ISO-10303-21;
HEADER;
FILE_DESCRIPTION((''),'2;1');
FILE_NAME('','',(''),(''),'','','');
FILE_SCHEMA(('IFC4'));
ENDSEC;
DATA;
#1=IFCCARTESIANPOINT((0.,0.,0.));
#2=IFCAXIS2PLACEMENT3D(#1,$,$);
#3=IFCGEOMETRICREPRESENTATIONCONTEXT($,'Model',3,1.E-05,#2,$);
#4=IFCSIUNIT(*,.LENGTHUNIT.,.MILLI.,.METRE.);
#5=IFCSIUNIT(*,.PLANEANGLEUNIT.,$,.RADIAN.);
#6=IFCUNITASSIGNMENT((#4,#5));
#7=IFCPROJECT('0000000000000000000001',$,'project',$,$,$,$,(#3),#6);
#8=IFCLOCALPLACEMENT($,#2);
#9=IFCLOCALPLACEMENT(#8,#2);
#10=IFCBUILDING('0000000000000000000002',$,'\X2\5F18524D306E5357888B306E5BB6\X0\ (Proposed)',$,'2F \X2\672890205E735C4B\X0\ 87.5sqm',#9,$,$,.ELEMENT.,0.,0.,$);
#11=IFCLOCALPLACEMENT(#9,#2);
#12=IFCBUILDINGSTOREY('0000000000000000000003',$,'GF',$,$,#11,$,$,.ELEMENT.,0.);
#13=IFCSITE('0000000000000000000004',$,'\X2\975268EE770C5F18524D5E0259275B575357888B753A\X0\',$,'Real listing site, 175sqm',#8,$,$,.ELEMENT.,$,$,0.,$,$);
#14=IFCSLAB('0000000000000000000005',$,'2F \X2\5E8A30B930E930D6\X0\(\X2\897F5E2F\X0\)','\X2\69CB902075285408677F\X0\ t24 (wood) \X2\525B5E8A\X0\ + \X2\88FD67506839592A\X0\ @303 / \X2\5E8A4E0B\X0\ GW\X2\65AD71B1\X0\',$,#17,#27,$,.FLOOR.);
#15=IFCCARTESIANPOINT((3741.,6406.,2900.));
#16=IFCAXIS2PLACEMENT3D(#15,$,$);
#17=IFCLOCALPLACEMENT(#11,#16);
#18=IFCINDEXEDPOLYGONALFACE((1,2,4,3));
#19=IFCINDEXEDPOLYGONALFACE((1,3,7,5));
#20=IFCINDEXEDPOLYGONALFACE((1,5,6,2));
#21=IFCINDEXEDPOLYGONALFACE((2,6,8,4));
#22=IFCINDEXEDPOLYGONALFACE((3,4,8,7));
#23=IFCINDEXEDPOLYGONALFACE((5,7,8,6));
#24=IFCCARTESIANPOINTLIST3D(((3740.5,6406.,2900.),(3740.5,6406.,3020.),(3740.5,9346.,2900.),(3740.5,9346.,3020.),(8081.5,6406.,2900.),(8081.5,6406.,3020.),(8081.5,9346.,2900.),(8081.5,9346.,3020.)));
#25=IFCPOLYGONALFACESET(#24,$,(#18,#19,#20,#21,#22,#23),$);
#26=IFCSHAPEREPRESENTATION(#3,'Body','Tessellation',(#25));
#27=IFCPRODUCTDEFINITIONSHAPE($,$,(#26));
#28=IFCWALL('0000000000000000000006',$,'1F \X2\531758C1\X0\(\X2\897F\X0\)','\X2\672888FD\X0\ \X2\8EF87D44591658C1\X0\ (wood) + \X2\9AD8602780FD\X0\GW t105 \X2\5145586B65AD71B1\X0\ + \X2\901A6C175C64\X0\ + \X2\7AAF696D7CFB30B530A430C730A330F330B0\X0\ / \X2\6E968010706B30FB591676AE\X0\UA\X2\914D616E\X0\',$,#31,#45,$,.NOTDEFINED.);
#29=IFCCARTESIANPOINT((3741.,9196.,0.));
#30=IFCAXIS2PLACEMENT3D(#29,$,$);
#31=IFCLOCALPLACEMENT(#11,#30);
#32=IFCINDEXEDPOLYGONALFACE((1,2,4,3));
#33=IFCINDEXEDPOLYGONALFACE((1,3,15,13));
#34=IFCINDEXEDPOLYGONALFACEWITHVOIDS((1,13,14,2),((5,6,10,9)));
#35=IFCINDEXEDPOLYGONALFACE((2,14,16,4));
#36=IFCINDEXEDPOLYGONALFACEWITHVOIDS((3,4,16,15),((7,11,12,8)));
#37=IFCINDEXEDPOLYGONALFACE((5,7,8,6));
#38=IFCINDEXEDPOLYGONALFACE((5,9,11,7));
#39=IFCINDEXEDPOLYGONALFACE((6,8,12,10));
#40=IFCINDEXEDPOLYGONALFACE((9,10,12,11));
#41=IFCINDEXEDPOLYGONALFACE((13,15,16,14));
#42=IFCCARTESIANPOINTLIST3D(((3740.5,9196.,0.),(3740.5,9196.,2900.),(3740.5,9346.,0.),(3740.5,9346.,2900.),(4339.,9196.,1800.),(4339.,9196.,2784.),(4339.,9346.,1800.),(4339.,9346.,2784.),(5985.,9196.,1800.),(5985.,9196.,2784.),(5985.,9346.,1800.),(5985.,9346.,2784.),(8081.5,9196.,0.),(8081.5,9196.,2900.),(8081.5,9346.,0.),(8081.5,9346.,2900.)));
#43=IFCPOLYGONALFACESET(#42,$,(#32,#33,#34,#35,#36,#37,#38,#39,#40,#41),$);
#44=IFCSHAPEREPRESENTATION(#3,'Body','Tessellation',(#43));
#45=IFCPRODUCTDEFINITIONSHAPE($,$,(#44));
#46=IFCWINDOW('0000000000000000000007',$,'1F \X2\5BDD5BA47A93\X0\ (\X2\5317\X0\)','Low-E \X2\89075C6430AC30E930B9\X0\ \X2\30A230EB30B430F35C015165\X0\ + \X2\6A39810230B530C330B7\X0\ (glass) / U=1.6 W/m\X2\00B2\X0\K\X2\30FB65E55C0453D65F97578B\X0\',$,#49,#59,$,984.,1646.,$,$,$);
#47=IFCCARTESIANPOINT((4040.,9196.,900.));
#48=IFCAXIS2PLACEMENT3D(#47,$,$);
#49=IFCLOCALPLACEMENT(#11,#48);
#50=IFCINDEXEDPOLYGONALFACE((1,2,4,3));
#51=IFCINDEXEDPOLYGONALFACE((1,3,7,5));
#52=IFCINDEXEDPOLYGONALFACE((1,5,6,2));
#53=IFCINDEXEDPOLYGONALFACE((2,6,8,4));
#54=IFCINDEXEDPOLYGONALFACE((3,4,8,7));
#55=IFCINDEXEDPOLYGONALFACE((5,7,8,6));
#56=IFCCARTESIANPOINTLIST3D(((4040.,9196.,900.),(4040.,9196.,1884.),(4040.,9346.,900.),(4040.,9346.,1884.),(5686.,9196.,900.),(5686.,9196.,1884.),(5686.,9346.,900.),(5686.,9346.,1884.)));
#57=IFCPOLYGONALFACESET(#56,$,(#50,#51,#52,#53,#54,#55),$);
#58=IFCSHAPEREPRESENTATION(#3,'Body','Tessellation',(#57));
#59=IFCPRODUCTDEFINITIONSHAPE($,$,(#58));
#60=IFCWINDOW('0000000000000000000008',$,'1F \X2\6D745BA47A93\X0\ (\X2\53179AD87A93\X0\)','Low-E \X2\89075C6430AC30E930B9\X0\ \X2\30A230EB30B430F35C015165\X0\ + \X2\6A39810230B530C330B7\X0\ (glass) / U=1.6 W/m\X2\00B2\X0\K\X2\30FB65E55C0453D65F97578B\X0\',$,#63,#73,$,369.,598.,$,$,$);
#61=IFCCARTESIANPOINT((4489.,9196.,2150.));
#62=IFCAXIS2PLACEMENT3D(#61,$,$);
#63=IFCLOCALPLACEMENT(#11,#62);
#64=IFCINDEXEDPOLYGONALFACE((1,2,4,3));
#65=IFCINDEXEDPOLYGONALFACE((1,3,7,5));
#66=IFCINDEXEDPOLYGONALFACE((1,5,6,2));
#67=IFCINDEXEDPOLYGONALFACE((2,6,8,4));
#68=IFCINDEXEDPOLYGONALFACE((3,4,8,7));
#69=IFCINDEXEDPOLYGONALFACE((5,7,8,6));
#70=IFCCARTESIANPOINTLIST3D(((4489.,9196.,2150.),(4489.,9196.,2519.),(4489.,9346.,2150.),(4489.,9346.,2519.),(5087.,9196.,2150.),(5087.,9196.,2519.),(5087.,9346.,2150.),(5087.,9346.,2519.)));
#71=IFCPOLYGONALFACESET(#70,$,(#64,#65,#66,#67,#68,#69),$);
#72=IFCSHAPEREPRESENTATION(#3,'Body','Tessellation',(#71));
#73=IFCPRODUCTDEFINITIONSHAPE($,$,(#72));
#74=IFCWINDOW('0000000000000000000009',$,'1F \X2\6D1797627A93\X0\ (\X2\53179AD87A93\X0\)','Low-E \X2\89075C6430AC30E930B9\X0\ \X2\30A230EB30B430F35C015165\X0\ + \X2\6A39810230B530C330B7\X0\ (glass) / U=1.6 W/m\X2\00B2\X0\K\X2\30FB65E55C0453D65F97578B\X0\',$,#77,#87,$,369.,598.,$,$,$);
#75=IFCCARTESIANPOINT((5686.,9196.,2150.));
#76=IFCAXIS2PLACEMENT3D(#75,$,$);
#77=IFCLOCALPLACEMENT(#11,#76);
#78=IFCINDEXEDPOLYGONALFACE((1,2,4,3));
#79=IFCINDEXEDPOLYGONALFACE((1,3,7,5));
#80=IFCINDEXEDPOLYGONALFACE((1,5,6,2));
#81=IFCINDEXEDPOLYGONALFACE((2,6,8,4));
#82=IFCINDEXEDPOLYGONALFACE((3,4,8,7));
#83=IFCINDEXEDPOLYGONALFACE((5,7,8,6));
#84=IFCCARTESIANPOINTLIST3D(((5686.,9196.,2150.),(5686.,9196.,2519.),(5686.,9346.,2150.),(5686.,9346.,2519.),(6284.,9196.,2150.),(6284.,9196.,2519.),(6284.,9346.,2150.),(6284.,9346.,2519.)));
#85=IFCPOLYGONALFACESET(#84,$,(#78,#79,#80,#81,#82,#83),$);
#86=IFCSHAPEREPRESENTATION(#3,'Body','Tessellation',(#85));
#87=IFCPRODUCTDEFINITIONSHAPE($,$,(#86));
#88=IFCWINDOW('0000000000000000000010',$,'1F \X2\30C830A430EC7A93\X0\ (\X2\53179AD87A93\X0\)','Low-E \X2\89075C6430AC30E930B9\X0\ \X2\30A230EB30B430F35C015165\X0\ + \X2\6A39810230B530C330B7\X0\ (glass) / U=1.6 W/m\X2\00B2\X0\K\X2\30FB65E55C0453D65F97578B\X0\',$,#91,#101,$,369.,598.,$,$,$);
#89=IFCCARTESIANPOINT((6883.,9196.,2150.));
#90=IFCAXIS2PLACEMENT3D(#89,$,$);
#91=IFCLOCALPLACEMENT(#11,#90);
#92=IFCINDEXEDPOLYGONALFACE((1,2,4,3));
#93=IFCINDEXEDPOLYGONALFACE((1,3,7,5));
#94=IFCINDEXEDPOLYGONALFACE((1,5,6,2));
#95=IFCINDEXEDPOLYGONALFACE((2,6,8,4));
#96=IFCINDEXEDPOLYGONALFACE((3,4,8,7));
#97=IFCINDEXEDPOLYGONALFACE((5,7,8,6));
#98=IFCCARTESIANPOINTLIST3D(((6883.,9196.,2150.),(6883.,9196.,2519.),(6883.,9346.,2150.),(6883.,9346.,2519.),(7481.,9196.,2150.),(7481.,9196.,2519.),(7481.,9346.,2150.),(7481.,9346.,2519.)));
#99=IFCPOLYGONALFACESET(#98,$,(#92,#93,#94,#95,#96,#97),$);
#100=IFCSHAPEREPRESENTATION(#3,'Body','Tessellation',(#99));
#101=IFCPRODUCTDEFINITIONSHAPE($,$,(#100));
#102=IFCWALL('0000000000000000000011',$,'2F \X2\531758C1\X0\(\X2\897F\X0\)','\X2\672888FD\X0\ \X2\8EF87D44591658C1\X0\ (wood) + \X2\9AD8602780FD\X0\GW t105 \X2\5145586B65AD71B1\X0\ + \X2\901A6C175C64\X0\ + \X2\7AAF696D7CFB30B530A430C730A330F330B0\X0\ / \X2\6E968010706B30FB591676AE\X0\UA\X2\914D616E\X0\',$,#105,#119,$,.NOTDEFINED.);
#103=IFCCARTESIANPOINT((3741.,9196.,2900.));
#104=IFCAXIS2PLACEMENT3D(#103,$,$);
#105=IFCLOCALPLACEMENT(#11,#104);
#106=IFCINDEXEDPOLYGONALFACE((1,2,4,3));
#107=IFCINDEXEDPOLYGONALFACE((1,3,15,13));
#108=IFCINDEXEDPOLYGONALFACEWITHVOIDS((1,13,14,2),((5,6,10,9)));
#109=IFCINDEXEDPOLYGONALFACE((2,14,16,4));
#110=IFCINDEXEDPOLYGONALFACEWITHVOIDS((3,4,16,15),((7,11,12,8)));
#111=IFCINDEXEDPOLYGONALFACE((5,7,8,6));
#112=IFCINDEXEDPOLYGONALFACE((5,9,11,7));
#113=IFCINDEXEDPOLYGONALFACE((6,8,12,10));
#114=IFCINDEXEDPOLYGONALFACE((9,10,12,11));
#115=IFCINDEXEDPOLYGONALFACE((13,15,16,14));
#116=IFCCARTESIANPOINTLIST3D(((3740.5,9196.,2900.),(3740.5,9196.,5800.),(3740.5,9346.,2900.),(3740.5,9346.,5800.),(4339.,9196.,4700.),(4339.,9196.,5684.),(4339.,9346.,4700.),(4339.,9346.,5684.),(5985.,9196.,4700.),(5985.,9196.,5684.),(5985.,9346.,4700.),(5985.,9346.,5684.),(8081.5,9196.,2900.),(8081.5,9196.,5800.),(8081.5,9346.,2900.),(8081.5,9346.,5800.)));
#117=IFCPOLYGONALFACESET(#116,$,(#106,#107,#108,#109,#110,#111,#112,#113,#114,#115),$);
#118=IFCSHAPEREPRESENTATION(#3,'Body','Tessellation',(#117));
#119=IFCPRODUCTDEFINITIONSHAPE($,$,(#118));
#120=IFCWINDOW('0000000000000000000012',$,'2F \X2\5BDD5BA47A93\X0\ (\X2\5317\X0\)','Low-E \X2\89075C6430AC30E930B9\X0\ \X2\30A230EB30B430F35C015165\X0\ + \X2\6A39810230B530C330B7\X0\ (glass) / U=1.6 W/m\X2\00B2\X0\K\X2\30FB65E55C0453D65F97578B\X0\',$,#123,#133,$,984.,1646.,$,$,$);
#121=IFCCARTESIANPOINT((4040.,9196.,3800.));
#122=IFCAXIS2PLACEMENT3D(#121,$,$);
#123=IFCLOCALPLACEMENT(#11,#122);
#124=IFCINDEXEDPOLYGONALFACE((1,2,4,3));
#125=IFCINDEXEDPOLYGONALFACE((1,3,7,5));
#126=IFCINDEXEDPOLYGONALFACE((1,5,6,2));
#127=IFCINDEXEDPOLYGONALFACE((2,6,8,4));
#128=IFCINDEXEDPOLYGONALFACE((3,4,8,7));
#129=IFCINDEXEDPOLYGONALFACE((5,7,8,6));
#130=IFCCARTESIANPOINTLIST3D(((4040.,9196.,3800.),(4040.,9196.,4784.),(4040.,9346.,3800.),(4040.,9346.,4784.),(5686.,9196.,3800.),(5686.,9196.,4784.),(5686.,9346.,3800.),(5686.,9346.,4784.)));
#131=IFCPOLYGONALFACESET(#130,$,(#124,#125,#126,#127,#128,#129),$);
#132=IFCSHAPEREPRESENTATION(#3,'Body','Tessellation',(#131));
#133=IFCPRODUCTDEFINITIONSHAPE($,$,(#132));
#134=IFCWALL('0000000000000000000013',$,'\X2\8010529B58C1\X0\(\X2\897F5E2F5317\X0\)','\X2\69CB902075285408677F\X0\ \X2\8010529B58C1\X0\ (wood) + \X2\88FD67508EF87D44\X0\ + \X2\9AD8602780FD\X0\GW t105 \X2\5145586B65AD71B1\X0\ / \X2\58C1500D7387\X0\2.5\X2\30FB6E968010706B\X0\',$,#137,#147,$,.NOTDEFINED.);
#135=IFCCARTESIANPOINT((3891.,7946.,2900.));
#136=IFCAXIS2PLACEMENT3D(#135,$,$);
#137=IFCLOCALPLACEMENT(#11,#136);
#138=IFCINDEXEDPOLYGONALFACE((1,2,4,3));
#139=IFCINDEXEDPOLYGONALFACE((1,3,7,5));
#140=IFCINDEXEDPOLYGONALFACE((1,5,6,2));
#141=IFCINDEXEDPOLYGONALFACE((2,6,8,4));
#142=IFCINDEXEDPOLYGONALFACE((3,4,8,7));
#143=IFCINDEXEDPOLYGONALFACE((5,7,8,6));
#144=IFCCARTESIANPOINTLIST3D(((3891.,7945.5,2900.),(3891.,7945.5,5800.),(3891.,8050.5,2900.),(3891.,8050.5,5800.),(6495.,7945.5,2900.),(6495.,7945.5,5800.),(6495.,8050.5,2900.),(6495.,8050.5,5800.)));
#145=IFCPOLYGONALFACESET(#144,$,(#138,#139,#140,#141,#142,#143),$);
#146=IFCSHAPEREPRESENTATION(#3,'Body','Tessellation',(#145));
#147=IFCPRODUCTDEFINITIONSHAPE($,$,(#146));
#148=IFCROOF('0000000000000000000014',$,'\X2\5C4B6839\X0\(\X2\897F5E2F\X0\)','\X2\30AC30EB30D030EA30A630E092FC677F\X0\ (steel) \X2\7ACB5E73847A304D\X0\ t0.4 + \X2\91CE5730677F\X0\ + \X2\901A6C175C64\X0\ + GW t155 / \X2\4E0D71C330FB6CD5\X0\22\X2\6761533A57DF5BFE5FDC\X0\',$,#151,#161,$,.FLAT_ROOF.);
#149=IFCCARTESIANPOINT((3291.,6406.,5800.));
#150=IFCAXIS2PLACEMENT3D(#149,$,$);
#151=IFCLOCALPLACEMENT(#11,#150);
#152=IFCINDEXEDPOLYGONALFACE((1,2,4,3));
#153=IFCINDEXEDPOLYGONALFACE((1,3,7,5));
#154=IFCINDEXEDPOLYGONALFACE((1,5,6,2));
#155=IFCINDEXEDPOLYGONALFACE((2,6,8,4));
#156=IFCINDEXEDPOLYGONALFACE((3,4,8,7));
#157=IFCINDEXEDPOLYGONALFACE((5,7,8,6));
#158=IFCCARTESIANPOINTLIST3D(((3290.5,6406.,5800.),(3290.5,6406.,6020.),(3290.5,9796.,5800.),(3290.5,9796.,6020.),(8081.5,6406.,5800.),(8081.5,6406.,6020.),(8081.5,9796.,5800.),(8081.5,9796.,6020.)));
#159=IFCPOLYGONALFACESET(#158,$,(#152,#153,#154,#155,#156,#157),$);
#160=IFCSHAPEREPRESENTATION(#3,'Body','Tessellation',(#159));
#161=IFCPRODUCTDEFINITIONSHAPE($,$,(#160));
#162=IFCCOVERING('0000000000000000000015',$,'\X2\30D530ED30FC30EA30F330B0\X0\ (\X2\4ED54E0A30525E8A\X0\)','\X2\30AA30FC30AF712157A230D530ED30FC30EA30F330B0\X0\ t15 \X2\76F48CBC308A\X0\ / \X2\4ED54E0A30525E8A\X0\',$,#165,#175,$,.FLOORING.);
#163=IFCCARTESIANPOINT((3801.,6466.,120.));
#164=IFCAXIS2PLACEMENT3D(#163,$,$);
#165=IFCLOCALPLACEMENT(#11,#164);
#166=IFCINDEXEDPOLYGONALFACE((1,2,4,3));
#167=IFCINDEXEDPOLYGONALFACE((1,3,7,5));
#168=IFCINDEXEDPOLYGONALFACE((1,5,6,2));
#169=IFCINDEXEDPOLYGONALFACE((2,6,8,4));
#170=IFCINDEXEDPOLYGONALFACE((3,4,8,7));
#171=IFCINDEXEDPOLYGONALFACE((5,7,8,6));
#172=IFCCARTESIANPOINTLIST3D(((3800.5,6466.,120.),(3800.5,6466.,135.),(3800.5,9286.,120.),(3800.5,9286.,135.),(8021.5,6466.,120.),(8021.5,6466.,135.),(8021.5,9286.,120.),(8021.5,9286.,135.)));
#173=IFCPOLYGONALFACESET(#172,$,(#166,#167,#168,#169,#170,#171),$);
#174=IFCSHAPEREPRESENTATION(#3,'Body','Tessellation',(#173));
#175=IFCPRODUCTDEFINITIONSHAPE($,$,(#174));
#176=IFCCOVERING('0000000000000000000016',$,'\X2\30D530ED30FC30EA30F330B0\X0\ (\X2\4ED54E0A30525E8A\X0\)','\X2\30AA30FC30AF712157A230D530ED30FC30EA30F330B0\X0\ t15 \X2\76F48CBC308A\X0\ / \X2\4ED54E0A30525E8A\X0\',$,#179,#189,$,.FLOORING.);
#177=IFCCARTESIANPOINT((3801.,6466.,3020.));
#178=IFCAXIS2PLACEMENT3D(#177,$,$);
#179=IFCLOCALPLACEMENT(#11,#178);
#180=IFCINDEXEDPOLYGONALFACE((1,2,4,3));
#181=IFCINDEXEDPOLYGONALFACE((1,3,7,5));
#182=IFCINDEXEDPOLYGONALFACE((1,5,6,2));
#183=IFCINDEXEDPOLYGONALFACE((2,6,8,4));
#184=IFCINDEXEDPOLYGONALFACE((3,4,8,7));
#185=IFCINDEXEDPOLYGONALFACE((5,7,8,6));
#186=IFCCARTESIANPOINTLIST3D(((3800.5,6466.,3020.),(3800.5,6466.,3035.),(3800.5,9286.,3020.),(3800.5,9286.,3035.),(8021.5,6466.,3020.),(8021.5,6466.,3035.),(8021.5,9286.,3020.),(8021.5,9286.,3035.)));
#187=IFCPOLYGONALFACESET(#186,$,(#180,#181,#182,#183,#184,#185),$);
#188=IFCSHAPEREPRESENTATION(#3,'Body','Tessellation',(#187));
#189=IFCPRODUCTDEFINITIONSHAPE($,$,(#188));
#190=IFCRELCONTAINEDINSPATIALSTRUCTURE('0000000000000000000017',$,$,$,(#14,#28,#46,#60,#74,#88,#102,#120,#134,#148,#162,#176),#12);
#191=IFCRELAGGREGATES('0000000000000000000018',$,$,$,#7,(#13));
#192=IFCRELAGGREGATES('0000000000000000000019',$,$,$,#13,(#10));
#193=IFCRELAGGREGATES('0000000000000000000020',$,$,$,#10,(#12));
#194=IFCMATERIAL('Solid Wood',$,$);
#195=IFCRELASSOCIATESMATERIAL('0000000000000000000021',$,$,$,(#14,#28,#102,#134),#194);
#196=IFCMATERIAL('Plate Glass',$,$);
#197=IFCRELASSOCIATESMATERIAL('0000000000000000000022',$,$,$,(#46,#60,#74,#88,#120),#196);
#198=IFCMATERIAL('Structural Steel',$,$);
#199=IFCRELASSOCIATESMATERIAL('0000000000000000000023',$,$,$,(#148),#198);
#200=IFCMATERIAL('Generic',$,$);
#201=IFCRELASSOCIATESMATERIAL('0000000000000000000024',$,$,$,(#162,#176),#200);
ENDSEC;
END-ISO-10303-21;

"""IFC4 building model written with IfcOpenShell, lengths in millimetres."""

from ifc_helpers import new_model, si_unit, frame, frame_2d, origin, place, context, project, spatial, rectangle, extrude, material, element, fill, save


model = new_model("IFC4")

# Units and contexts
model_context = context("Model", 3, precision=1e-05, world=origin())
ifc_project = project(units=[si_unit("LENGTHUNIT", "METRE", prefix="MILLI"), si_unit("PLANEANGLEUNIT", "RADIAN")], contexts=[model_context])

# Site, building, storey
site_placement = place(None, origin())
site = spatial("IfcSite", under=ifc_project, at=site_placement, Name="青森県弘前市大字南袋町", ObjectType="Real listing site, 175sqm", CompositionType="ELEMENT", RefElevation=0.0)
building_placement = place(site_placement, origin())
building = spatial("IfcBuilding", under=site, at=building_placement, Name="弘前の南袋の家 (Proposed)", ObjectType="2F 木造平屋 87.5sqm", CompositionType="ELEMENT", ElevationOfRefHeight=0.0, ElevationOfTerrain=0.0)
storey_placement = place(building_placement, origin())
storey = spatial("IfcBuildingStorey", under=building, at=storey_placement, Name="GF", CompositionType="ELEMENT", Elevation=0.0)

# Slab
ifc_material_1 = material(Name="Solid Wood")
slab_1_placement = place(storey_placement, frame((3741.0, 6406.0, 2900.0)))
element("IfcSlab", 1, at=slab_1_placement, inside=storey, material=ifc_material_1, Name="2F 床スラブ(西帯)", Description="構造用合板 t24 (wood) 剛床 + 製材根太 @303 / 床下 GW断熱", PredefinedType="FLOOR", context=model_context, shape_type="SweptSolid", body=[
    extrude(rectangle(XDim=4341.0, YDim=2940.0, at=frame_2d((2170.0, 1470.0))), frame((3741.0, 6406.0, 2900.0)), (0.0, 0.0, 1.0), 120.0),
])

# Wall, openings, windows
wall_1_placement = place(storey_placement, frame((3741.0, 9196.0, 0.0)))
wall_1 = element("IfcWall", 2, at=wall_1_placement, inside=storey, material=ifc_material_1, Name="1F 北壁(西)", Description="木製 軸組外壁 (wood) + 高性能GW t105 充填断熱 + 通気層 + 窯業系サイディング / 準耐火・外皮UA配慮", PredefinedType="NOTDEFINED", context=model_context, shape_type="SweptSolid", body=[
    extrude(rectangle(XDim=4341.0, YDim=150.0, at=frame_2d((2170.0, 75.0))), frame((3741.0, 9196.0, 0.0)), (0.0, 0.0, 1.0), 2900.0),
])
opening_1_placement = place(storey_placement, frame((4040.0, 9196.0, 900.0)))
opening_1 = element("IfcOpeningElement", 3, at=opening_1_placement, cuts=wall_1, PredefinedType="NOTDEFINED", context=model_context, shape_type="SweptSolid", body=[
    extrude(rectangle(XDim=1646.0, YDim=150.0, at=frame_2d((823.0, 75.0))), frame((4040.0, 9196.0, 900.0)), (0.0, 0.0, 1.0), 984.0),
])
opening_2_placement = place(storey_placement, frame((4489.0, 9196.0, 2150.0)))
opening_2 = element("IfcOpeningElement", 4, at=opening_2_placement, cuts=wall_1, PredefinedType="NOTDEFINED", context=model_context, shape_type="SweptSolid", body=[
    extrude(rectangle(XDim=598.0, YDim=150.0, at=frame_2d((299.0, 75.0))), frame((4489.0, 9196.0, 2150.0)), (0.0, 0.0, 1.0), 369.0),
])
opening_3_placement = place(storey_placement, frame((5686.0, 9196.0, 2150.0)))
opening_3 = element("IfcOpeningElement", 5, at=opening_3_placement, cuts=wall_1, PredefinedType="NOTDEFINED", context=model_context, shape_type="SweptSolid", body=[
    extrude(rectangle(XDim=598.0, YDim=150.0, at=frame_2d((299.0, 75.0))), frame((5686.0, 9196.0, 2150.0)), (0.0, 0.0, 1.0), 369.0),
])
opening_4_placement = place(storey_placement, frame((6883.0, 9196.0, 2150.0)))
opening_4 = element("IfcOpeningElement", 6, at=opening_4_placement, cuts=wall_1, PredefinedType="NOTDEFINED", context=model_context, shape_type="SweptSolid", body=[
    extrude(rectangle(XDim=598.0, YDim=150.0, at=frame_2d((299.0, 75.0))), frame((6883.0, 9196.0, 2150.0)), (0.0, 0.0, 1.0), 369.0),
])
ifc_material_2 = material(Name="Plate Glass")
window_1_placement = place(storey_placement, frame((4040.0, 9196.0, 900.0)))
window_1 = element("IfcWindow", 7, at=window_1_placement, inside=storey, material=ifc_material_2, Name="1F 寝室窓 (北)", Description="Low-E 複層ガラス アルゴン封入 + 樹脂サッシ (glass) / U=1.6 W/m²K・日射取得型", OverallHeight=984.0, OverallWidth=1646.0, context=model_context, shape_type="SweptSolid", body=[
    extrude(rectangle(XDim=1646.0, YDim=150.0, at=frame_2d((823.0, 75.0))), frame((4040.0, 9196.0, 900.0)), (0.0, 0.0, 1.0), 984.0),
])
fill(opening_1, window_1)
window_2_placement = place(storey_placement, frame((4489.0, 9196.0, 2150.0)))
window_2 = element("IfcWindow", 8, at=window_2_placement, inside=storey, material=ifc_material_2, Name="1F 浴室窓 (北高窓)", Description="Low-E 複層ガラス アルゴン封入 + 樹脂サッシ (glass) / U=1.6 W/m²K・日射取得型", OverallHeight=369.0, OverallWidth=598.0, context=model_context, shape_type="SweptSolid", body=[
    extrude(rectangle(XDim=598.0, YDim=150.0, at=frame_2d((299.0, 75.0))), frame((4489.0, 9196.0, 2150.0)), (0.0, 0.0, 1.0), 369.0),
])
fill(opening_2, window_2)
window_3_placement = place(storey_placement, frame((5686.0, 9196.0, 2150.0)))
window_3 = element("IfcWindow", 9, at=window_3_placement, inside=storey, material=ifc_material_2, Name="1F 洗面窓 (北高窓)", Description="Low-E 複層ガラス アルゴン封入 + 樹脂サッシ (glass) / U=1.6 W/m²K・日射取得型", OverallHeight=369.0, OverallWidth=598.0, context=model_context, shape_type="SweptSolid", body=[
    extrude(rectangle(XDim=598.0, YDim=150.0, at=frame_2d((299.0, 75.0))), frame((5686.0, 9196.0, 2150.0)), (0.0, 0.0, 1.0), 369.0),
])
fill(opening_3, window_3)
window_4_placement = place(storey_placement, frame((6883.0, 9196.0, 2150.0)))
window_4 = element("IfcWindow", 10, at=window_4_placement, inside=storey, material=ifc_material_2, Name="1F トイレ窓 (北高窓)", Description="Low-E 複層ガラス アルゴン封入 + 樹脂サッシ (glass) / U=1.6 W/m²K・日射取得型", OverallHeight=369.0, OverallWidth=598.0, context=model_context, shape_type="SweptSolid", body=[
    extrude(rectangle(XDim=598.0, YDim=150.0, at=frame_2d((299.0, 75.0))), frame((6883.0, 9196.0, 2150.0)), (0.0, 0.0, 1.0), 369.0),
])
fill(opening_4, window_4)

# Wall, opening, window
wall_2_placement = place(storey_placement, frame((3741.0, 9196.0, 2900.0)))
wall_2 = element("IfcWall", 11, at=wall_2_placement, inside=storey, material=ifc_material_1, Name="2F 北壁(西)", Description="木製 軸組外壁 (wood) + 高性能GW t105 充填断熱 + 通気層 + 窯業系サイディング / 準耐火・外皮UA配慮", PredefinedType="NOTDEFINED", context=model_context, shape_type="SweptSolid", body=[
    extrude(rectangle(XDim=4341.0, YDim=150.0, at=frame_2d((2170.0, 75.0))), frame((3741.0, 9196.0, 2900.0)), (0.0, 0.0, 1.0), 2900.0),
])
opening_5_placement = place(storey_placement, frame((4040.0, 9196.0, 3800.0)))
opening_5 = element("IfcOpeningElement", 12, at=opening_5_placement, cuts=wall_2, PredefinedType="NOTDEFINED", context=model_context, shape_type="SweptSolid", body=[
    extrude(rectangle(XDim=1646.0, YDim=150.0, at=frame_2d((823.0, 75.0))), frame((4040.0, 9196.0, 3800.0)), (0.0, 0.0, 1.0), 984.0),
])
window_5_placement = place(storey_placement, frame((4040.0, 9196.0, 3800.0)))
window_5 = element("IfcWindow", 13, at=window_5_placement, inside=storey, material=ifc_material_2, Name="2F 寝室窓 (北)", Description="Low-E 複層ガラス アルゴン封入 + 樹脂サッシ (glass) / U=1.6 W/m²K・日射取得型", OverallHeight=984.0, OverallWidth=1646.0, context=model_context, shape_type="SweptSolid", body=[
    extrude(rectangle(XDim=1646.0, YDim=150.0, at=frame_2d((823.0, 75.0))), frame((4040.0, 9196.0, 3800.0)), (0.0, 0.0, 1.0), 984.0),
])
fill(opening_5, window_5)

# Wall
wall_3_placement = place(storey_placement, frame((3891.0, 7946.0, 2900.0)))
element("IfcWall", 14, at=wall_3_placement, inside=storey, material=ifc_material_1, Name="耐力壁(西帯北)", Description="構造用合板 耐力壁 (wood) + 製材軸組 + 高性能GW t105 充填断熱 / 壁倍率2.5・準耐火", PredefinedType="NOTDEFINED", context=model_context, shape_type="SweptSolid", body=[
    extrude(rectangle(XDim=2604.0, YDim=105.0, at=frame_2d((1302.0, 52.0))), frame((3891.0, 7946.0, 2900.0)), (0.0, 0.0, 1.0), 2900.0),
])

# Roof
ifc_material_3 = material(Name="Structural Steel")
for number, where, name in (
    (15, (3291.0, 6406.0, 5800.0), "屋根(西帯)"),
):
    element("IfcRoof", number, at=place(storey_placement, frame(where)), inside=storey, material=ifc_material_3, Name=name, Description="ガルバリウム鋼板 (steel) 立平葺き t0.4 + 野地板 + 通気層 + GW t155 / 不燃・法22条区域対応", PredefinedType="FLAT_ROOF", context=model_context, shape_type="SweptSolid", body=[
        extrude(rectangle(XDim=4791.0, YDim=3390.0, at=frame_2d((2395.0, 1695.0))), frame((3291.0, 6406.0, 5800.0)), (0.0, 0.0, 1.0), 220.0),
    ])

# Coverings
ifc_material_4 = material(Name="Generic")
covering_1_placement = place(storey_placement, frame((3801.0, 6466.0, 120.0)))
element("IfcCovering", 16, at=covering_1_placement, inside=storey, material=ifc_material_4, Name="フローリング (仕上げ床)", Description="オーク無垢フローリング t15 直貼り / 仕上げ床", PredefinedType="FLOORING", context=model_context, shape_type="SweptSolid", body=[
    extrude(rectangle(XDim=4221.0, YDim=2820.0, at=frame_2d((2110.0, 1410.0))), frame((3801.0, 6466.0, 120.0)), (0.0, 0.0, 1.0), 15.0),
])
covering_2_placement = place(storey_placement, frame((3801.0, 6466.0, 3020.0)))
element("IfcCovering", 17, at=covering_2_placement, inside=storey, material=ifc_material_4, Name="フローリング (仕上げ床)", Description="オーク無垢フローリング t15 直貼り / 仕上げ床", PredefinedType="FLOORING", context=model_context, shape_type="SweptSolid", body=[
    extrude(rectangle(XDim=4221.0, YDim=2820.0, at=frame_2d((2110.0, 1410.0))), frame((3801.0, 6466.0, 3020.0)), (0.0, 0.0, 1.0), 15.0),
])

save(model, "model.ifc")
